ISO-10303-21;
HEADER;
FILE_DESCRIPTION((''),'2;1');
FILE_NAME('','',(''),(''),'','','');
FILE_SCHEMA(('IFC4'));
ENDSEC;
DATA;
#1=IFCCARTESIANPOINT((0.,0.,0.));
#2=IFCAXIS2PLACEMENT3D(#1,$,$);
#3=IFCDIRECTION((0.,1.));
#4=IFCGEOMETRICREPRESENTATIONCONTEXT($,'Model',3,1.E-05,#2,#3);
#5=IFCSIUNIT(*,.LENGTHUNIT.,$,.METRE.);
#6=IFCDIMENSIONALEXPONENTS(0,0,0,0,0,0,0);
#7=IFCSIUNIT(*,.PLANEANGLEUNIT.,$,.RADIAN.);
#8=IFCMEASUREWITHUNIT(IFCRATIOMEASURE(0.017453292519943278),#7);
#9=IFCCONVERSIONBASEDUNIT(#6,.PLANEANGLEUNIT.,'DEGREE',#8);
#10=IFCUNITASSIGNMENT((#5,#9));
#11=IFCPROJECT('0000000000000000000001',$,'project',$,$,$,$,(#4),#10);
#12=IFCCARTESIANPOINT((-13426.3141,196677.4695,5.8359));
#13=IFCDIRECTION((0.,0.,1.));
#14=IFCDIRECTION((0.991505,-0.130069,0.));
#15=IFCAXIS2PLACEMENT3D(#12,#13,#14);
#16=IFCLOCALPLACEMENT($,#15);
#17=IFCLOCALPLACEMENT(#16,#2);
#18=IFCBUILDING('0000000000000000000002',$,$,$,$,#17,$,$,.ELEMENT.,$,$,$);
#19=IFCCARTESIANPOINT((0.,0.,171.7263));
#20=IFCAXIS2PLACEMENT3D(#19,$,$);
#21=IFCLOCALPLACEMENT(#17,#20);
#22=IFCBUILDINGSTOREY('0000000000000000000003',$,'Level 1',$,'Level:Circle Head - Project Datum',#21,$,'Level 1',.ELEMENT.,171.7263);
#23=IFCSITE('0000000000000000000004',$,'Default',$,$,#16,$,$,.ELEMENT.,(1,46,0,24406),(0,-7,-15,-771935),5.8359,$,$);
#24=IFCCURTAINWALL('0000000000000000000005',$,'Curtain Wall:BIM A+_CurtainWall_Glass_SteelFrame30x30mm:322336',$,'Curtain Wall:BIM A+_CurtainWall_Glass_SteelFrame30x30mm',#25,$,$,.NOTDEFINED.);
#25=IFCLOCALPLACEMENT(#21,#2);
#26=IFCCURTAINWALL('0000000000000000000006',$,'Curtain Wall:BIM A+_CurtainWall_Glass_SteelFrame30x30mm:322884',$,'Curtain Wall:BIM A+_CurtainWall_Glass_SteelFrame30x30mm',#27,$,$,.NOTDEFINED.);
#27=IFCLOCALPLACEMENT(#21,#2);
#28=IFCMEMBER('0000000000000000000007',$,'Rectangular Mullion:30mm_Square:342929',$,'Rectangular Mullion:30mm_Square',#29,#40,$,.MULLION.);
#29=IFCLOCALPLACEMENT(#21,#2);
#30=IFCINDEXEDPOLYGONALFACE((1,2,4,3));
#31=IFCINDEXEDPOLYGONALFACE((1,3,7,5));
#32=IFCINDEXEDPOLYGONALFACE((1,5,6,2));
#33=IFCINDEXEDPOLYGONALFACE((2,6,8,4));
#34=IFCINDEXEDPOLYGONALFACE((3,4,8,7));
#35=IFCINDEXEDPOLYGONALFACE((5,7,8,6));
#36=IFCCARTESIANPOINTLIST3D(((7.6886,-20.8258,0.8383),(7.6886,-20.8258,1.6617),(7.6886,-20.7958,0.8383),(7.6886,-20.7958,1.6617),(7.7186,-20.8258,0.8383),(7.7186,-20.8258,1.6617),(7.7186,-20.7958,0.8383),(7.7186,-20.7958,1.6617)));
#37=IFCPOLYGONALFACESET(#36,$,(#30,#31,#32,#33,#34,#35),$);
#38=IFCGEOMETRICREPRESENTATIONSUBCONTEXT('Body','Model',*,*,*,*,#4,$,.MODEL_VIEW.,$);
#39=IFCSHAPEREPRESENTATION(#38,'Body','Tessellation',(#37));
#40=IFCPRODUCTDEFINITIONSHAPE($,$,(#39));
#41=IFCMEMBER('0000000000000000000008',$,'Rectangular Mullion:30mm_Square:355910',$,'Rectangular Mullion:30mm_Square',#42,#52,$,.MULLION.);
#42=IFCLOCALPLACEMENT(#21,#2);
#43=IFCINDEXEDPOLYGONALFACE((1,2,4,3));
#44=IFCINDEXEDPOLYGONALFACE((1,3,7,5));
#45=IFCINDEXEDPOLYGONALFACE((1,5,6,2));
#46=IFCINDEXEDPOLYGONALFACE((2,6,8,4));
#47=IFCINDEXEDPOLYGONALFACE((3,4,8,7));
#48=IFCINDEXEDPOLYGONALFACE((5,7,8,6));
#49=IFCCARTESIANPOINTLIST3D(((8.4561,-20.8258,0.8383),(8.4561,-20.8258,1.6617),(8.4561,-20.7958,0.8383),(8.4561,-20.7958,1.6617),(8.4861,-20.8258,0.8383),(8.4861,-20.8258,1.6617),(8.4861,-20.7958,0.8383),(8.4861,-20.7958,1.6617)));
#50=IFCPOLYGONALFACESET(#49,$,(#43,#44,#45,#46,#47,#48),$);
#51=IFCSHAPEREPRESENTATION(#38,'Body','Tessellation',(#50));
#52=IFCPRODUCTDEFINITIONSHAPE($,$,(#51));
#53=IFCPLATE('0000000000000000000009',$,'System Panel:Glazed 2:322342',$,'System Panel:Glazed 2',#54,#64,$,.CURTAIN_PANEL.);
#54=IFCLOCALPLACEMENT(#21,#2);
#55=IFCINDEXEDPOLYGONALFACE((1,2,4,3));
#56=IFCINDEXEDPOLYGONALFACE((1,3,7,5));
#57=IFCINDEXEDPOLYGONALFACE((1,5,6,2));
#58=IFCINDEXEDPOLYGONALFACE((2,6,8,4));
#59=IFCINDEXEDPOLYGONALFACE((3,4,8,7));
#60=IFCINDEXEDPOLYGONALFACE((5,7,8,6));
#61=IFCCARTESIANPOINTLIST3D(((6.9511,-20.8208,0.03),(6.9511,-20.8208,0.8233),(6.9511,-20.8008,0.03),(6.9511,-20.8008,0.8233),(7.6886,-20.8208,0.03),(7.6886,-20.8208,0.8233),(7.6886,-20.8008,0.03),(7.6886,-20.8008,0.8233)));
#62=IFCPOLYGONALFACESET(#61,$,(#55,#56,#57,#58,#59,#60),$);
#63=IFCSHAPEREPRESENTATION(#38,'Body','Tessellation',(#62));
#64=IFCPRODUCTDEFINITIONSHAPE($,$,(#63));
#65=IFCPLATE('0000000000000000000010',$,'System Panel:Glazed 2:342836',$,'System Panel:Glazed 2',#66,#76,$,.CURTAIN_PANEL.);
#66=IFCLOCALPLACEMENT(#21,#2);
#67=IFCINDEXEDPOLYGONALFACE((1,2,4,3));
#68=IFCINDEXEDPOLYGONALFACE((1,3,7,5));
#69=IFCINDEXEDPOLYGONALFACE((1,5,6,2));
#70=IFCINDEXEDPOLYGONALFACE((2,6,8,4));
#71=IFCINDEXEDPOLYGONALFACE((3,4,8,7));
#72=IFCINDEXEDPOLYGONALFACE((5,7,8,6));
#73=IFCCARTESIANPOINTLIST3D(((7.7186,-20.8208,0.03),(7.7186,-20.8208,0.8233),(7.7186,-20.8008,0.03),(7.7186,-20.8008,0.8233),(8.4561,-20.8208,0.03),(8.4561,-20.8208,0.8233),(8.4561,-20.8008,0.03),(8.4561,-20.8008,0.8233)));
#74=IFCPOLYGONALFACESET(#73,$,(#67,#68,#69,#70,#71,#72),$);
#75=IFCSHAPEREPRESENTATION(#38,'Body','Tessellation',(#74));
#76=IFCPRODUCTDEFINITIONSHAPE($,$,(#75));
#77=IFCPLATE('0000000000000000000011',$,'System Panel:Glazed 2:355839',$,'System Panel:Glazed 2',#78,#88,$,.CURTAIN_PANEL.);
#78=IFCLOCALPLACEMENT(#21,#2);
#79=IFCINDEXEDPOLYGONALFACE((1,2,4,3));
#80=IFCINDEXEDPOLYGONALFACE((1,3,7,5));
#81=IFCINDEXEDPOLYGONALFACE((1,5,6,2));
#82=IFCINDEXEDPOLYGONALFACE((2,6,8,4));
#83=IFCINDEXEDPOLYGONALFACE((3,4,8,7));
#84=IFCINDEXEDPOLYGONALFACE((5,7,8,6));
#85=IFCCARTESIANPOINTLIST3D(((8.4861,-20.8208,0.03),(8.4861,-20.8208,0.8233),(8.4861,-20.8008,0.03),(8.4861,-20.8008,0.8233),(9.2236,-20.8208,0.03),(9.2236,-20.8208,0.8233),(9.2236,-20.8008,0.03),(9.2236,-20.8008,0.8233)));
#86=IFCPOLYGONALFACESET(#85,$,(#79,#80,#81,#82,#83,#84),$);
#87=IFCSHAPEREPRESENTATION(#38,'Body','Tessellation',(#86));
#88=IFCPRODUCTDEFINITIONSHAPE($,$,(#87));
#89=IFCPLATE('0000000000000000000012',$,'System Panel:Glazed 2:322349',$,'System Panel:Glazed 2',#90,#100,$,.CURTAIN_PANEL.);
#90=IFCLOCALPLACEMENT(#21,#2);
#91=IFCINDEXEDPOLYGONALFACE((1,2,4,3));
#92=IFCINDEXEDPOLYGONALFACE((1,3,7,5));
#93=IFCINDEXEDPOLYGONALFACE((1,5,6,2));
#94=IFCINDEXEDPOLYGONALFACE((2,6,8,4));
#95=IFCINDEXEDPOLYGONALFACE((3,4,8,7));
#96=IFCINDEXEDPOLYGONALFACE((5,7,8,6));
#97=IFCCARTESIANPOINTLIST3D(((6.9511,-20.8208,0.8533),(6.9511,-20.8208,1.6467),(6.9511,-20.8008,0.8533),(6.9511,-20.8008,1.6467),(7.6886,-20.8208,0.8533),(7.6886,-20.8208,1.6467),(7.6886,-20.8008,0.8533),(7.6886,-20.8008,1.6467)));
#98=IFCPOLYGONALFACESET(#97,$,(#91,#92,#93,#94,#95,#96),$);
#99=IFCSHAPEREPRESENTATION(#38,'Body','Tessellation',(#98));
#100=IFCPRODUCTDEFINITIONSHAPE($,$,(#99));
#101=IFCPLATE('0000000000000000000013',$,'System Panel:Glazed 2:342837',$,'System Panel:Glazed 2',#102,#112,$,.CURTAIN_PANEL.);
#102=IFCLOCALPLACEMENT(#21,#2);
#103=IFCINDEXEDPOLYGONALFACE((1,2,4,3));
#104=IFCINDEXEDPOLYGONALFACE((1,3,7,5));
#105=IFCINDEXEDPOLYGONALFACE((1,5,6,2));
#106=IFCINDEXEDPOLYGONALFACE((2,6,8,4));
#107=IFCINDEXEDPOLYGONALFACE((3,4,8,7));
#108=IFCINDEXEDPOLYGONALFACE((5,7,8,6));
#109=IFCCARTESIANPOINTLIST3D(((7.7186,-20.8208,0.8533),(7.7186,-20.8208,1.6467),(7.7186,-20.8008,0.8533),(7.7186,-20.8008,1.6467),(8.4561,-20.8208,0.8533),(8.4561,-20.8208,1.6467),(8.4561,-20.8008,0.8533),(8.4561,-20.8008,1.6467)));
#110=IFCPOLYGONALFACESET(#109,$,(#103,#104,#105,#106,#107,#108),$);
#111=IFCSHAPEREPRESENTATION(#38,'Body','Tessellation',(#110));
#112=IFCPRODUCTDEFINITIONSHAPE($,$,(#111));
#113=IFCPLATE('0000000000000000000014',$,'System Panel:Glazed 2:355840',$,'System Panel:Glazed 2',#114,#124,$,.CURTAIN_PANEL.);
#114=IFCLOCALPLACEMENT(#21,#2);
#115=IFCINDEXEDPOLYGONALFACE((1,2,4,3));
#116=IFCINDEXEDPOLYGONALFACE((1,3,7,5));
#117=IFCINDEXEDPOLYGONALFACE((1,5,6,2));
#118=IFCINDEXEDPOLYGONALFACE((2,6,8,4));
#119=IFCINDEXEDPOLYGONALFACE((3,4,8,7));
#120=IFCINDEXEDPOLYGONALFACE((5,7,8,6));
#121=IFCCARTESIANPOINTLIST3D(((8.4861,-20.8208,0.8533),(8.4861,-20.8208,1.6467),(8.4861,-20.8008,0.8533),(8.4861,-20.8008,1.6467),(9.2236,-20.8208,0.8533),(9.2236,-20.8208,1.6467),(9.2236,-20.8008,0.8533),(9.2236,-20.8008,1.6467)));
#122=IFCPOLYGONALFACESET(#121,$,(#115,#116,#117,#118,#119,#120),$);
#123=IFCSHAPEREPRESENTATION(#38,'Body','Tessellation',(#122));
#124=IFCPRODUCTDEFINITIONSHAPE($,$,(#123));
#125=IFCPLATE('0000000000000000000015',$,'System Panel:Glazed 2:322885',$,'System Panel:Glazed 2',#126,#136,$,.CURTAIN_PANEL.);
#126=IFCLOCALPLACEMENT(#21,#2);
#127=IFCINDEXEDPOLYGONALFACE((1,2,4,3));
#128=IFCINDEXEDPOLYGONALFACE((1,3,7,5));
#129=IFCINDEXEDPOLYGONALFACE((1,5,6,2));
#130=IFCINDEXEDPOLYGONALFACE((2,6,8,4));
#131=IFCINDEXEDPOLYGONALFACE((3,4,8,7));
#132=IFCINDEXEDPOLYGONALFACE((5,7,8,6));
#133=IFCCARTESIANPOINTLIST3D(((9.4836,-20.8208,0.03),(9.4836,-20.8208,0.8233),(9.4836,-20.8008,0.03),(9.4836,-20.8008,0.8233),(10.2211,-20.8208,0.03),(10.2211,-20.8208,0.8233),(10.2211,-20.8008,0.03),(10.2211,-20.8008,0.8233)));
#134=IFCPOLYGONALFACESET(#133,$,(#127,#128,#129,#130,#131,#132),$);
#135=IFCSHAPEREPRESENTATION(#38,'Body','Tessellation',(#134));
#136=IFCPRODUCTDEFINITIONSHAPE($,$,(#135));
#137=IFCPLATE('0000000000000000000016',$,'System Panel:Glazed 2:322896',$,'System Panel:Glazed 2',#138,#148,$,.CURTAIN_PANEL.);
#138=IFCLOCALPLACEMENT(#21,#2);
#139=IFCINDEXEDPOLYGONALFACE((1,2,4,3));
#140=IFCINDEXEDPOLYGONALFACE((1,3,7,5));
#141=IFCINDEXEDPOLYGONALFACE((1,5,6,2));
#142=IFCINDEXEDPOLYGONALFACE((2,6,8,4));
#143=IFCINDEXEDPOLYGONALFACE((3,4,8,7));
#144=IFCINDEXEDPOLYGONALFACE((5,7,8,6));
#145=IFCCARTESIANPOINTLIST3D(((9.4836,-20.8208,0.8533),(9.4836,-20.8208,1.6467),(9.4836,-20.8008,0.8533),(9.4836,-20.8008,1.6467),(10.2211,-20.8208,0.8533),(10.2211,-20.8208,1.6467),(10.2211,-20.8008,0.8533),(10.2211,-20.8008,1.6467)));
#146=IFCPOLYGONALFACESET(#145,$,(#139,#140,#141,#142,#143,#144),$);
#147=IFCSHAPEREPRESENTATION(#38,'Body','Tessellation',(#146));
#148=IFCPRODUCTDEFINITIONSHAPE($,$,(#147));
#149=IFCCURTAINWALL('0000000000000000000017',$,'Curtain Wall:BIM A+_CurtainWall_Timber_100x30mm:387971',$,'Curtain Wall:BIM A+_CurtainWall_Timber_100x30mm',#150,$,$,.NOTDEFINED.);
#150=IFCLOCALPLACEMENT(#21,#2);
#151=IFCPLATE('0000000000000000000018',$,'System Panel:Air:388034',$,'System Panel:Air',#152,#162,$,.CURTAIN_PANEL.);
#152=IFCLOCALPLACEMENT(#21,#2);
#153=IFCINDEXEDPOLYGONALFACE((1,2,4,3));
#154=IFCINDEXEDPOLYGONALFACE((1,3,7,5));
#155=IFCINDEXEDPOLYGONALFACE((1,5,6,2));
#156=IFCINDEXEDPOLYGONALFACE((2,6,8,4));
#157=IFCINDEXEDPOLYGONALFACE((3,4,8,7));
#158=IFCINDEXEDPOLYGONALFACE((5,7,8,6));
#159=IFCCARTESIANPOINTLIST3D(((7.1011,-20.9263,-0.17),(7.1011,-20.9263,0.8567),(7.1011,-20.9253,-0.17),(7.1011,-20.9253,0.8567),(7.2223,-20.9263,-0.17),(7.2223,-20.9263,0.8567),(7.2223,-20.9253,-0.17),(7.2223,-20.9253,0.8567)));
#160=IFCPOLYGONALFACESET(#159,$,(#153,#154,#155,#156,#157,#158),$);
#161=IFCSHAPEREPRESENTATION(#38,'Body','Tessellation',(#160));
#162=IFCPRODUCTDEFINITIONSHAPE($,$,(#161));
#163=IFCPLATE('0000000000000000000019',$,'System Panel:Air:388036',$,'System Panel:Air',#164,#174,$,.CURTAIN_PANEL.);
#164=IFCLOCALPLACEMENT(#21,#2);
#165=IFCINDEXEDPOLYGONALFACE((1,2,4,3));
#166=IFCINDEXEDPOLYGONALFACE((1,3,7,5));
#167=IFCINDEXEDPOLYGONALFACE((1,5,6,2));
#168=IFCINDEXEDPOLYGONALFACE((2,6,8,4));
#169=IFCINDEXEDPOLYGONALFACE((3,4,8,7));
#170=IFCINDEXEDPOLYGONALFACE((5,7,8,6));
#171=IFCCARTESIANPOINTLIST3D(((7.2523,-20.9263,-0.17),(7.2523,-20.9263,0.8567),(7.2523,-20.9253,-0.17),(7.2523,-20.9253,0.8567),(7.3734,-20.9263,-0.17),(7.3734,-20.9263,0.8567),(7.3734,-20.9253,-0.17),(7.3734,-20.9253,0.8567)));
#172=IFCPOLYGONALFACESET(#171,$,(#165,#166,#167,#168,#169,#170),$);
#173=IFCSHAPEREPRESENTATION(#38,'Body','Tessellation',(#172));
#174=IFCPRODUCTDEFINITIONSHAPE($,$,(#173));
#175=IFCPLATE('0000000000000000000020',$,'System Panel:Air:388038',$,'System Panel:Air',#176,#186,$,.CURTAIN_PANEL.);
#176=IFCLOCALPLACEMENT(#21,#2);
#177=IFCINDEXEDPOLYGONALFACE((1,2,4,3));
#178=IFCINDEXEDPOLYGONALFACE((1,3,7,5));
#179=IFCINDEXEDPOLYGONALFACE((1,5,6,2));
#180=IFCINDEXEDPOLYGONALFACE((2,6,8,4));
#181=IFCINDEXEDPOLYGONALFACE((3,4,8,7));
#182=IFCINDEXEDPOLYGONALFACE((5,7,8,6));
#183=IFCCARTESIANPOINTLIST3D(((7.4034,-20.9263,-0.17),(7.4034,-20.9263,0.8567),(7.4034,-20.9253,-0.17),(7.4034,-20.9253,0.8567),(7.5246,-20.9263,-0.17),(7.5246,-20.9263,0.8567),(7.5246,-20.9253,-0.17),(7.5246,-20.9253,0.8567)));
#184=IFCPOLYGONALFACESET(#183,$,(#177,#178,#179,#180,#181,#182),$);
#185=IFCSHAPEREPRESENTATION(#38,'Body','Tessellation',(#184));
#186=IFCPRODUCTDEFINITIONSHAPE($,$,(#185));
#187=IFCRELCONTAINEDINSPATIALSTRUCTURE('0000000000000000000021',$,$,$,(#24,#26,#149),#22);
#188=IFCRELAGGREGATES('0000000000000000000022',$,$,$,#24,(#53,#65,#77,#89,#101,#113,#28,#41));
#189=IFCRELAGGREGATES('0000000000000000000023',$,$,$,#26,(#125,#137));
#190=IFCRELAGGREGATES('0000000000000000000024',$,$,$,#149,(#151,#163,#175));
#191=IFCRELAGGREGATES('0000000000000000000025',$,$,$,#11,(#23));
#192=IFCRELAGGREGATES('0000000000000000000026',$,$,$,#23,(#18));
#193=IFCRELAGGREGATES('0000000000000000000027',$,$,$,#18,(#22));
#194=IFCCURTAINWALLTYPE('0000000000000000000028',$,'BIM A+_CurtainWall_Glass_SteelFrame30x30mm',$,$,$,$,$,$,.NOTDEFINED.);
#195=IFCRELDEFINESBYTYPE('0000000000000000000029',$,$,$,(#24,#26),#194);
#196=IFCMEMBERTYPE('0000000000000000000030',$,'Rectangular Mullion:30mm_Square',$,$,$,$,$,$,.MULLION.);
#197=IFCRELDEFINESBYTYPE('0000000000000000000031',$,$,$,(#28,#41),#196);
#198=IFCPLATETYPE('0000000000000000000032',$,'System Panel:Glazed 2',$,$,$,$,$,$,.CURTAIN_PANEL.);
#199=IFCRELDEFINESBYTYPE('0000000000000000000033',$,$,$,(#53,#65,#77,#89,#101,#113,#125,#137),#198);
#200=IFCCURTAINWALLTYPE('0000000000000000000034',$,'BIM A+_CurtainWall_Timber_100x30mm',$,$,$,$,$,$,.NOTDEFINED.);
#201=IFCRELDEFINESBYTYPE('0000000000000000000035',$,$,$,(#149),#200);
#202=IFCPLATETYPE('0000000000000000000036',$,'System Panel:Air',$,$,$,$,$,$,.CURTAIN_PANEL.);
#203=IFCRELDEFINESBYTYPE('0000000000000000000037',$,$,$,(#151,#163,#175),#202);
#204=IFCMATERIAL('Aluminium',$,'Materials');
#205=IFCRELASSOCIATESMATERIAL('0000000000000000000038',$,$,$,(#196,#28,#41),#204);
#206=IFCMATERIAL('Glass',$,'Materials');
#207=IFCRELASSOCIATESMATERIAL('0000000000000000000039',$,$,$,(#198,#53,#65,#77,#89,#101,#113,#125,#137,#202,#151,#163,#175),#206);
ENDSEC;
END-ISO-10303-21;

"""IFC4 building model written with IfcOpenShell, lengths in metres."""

from ifc_helpers import new_model, entity, si_unit, converted_unit, direction, frame, origin, place, context, subcontext, project, spatial, indexed_curve, outline, extrude, source, transform, mapped, material, type_object, type_shapes, element, aggregate, save


model = new_model("IFC4")

# Units and contexts
model_context = context("Model", 3, precision=1e-05, world=origin(), true_north=direction((0.0, 1.0)))
body_context = subcontext(model_context, "Body", "Model", "MODEL_VIEW")
ifc_project = project(units=[si_unit("LENGTHUNIT", "METRE"), converted_unit("PLANEANGLEUNIT", "DEGREE", entity("IfcRatioMeasure", 0.017453292519943278), si_unit("PLANEANGLEUNIT", "RADIAN"), dimensions=[0, 0, 0, 0, 0, 0, 0])], contexts=[model_context])

# Site, building, storey
site_placement = place(None, frame((-13426.3141, 196677.4695, 5.8359), z_axis=(0.0, 0.0, 1.0), x_axis=(0.991505, -0.130069, 0.0)))
site = spatial("IfcSite", under=ifc_project, at=site_placement, Name="Default", CompositionType="ELEMENT", RefLatitude=(1, 46, 0, 24406), RefLongitude=(0, -7, -15, -771935), RefElevation=5.8359)
building_placement = place(site_placement, origin())
building = spatial("IfcBuilding", under=site, at=building_placement, CompositionType="ELEMENT")
storey_placement = place(building_placement, frame((0.0, 0.0, 171.7263)))
storey = spatial("IfcBuildingStorey", under=building, at=storey_placement, Name="Level 1", ObjectType="Level:Circle Head - Project Datum", LongName="Level 1", CompositionType="ELEMENT", Elevation=171.7263)

# Curtain wall
curtain_wall_type_1 = type_object("IfcCurtainWallType", Name="BIM A+_CurtainWall_Glass_SteelFrame30x30mm", PredefinedType="NOTDEFINED")
curtain_wall_1_placement = place(storey_placement, frame((0.0, 0.0, -171.7263)))
curtain_wall_1 = element("IfcCurtainWall", 1, at=curtain_wall_1_placement, inside=storey, type_object=curtain_wall_type_1, Name="Curtain Wall:BIM A+_CurtainWall_Glass_SteelFrame30x30mm:322336", ObjectType="Curtain Wall:BIM A+_CurtainWall_Glass_SteelFrame30x30mm", PredefinedType="NOTDEFINED")
ifc_material_1 = material(Name="Aluminium", Category="Materials")

# Curtain wall
curtain_wall_2_placement = place(storey_placement, frame((0.0, 0.0, -171.7263)))
curtain_wall_2 = element("IfcCurtainWall", 2, at=curtain_wall_2_placement, inside=storey, type_object=curtain_wall_type_1, Name="Curtain Wall:BIM A+_CurtainWall_Glass_SteelFrame30x30mm:322884", ObjectType="Curtain Wall:BIM A+_CurtainWall_Glass_SteelFrame30x30mm", PredefinedType="NOTDEFINED")

# Members
member_type_1 = type_object("IfcMemberType", Name="Rectangular Mullion:30mm_Square", PredefinedType="MULLION", material=ifc_material_1)
shared_shape_1 = source(origin(), body_context, "Body", "SweptSolid", [
    extrude(outline(indexed_curve([(-0.015, -0.015), (0.015, -0.015), (0.015, 0.015), (-0.015, 0.015), (-0.015, -0.015)], self_intersect=False)), frame((0.0, 0.0, -0.8233), z_axis=(0.0, 0.0, 1.0), x_axis=(0.0, -1.0, 0.0)), (0.0, 0.0, 1.0), 0.8233),
])
type_shapes(member_type_1, [shared_shape_1])
member_1_placement = place(curtain_wall_1_placement, frame((7.7036, -20.8108, 172.5646), z_axis=(0.0, 0.0, -1.0), x_axis=(1.0, 0.0, 0.0)))
member_1 = element("IfcMember", 3, at=member_1_placement, type_object=member_type_1, material=ifc_material_1, Name="Rectangular Mullion:30mm_Square:342929", ObjectType="Rectangular Mullion:30mm_Square", PredefinedType="MULLION", context=body_context, shape_type="MappedRepresentation", body=[
    mapped(shared_shape_1, transform((0.0, 0.0, 0.0), scale=1.0)),
])
member_2_placement = place(curtain_wall_1_placement, frame((8.4711, -20.8108, 172.5646), z_axis=(0.0, 0.0, -1.0), x_axis=(1.0, 0.0, 0.0)))
member_2 = element("IfcMember", 4, at=member_2_placement, type_object=member_type_1, material=ifc_material_1, Name="Rectangular Mullion:30mm_Square:355910", ObjectType="Rectangular Mullion:30mm_Square", PredefinedType="MULLION", context=body_context, shape_type="MappedRepresentation", body=[
    mapped(shared_shape_1, transform((0.0, 0.0, 0.0), scale=1.0)),
])

# Plates
ifc_material_2 = material(Name="Glass", Category="Materials")
plate_type_1 = type_object("IfcPlateType", Name="System Panel:Glazed 2", PredefinedType="CURTAIN_PANEL", material=ifc_material_2)
shared_shape_2 = source(origin(), body_context, "Body", "SweptSolid", [
    extrude(outline(indexed_curve([(-0.01, -0.3688), (0.01, -0.3688), (0.01, 0.3688), (-0.01, 0.3688), (-0.01, -0.3688)], self_intersect=False)), frame((0.0, 0.0, 0.0), z_axis=(0.0, 0.0, 1.0), x_axis=(0.0, 1.0, 0.0)), (0.0, 0.0, 1.0), 0.7933),
])
type_shapes(plate_type_1, [shared_shape_2])
plate_1_placement = place(curtain_wall_1_placement, frame((7.3198, -20.8108, 171.7563)))
plate_1 = element("IfcPlate", 5, at=plate_1_placement, type_object=plate_type_1, material=ifc_material_2, Name="System Panel:Glazed 2:322342", ObjectType="System Panel:Glazed 2", PredefinedType="CURTAIN_PANEL", context=body_context, shape_type="MappedRepresentation", body=[
    mapped(shared_shape_2, transform((0.0, 0.0, 0.0), scale=1.0)),
])
plate_2_placement = place(curtain_wall_1_placement, frame((8.0873, -20.8108, 171.7563)))
plate_2 = element("IfcPlate", 6, at=plate_2_placement, type_object=plate_type_1, material=ifc_material_2, Name="System Panel:Glazed 2:342836", ObjectType="System Panel:Glazed 2", PredefinedType="CURTAIN_PANEL", context=body_context, shape_type="MappedRepresentation", body=[
    mapped(shared_shape_2, transform((0.0, 0.0, 0.0), scale=1.0)),
])
plate_3_placement = place(curtain_wall_1_placement, frame((8.8548, -20.8108, 171.7563)))
plate_3 = element("IfcPlate", 7, at=plate_3_placement, type_object=plate_type_1, material=ifc_material_2, Name="System Panel:Glazed 2:355839", ObjectType="System Panel:Glazed 2", PredefinedType="CURTAIN_PANEL", context=body_context, shape_type="MappedRepresentation", body=[
    mapped(shared_shape_2, transform((0.0, 0.0, 0.0), scale=1.0)),
])
plate_4_placement = place(curtain_wall_1_placement, frame((7.3198, -20.8108, 172.5796)))
plate_4 = element("IfcPlate", 8, at=plate_4_placement, type_object=plate_type_1, material=ifc_material_2, Name="System Panel:Glazed 2:322349", ObjectType="System Panel:Glazed 2", PredefinedType="CURTAIN_PANEL", context=body_context, shape_type="MappedRepresentation", body=[
    mapped(shared_shape_2, transform((0.0, 0.0, 0.0), scale=1.0)),
])
plate_5_placement = place(curtain_wall_1_placement, frame((8.0873, -20.8108, 172.5796)))
plate_5 = element("IfcPlate", 9, at=plate_5_placement, type_object=plate_type_1, material=ifc_material_2, Name="System Panel:Glazed 2:342837", ObjectType="System Panel:Glazed 2", PredefinedType="CURTAIN_PANEL", context=body_context, shape_type="MappedRepresentation", body=[
    mapped(shared_shape_2, transform((0.0, 0.0, 0.0), scale=1.0)),
])
plate_6_placement = place(curtain_wall_1_placement, frame((8.8548, -20.8108, 172.5796)))
plate_6 = element("IfcPlate", 10, at=plate_6_placement, type_object=plate_type_1, material=ifc_material_2, Name="System Panel:Glazed 2:355840", ObjectType="System Panel:Glazed 2", PredefinedType="CURTAIN_PANEL", context=body_context, shape_type="MappedRepresentation", body=[
    mapped(shared_shape_2, transform((0.0, 0.0, 0.0), scale=1.0)),
])
aggregate(curtain_wall_1, [plate_1, plate_2, plate_3, plate_4, plate_5, plate_6, member_1, member_2])
plate_7_placement = place(curtain_wall_2_placement, frame((9.8523, -20.8108, 171.7563)))
plate_7 = element("IfcPlate", 11, at=plate_7_placement, type_object=plate_type_1, material=ifc_material_2, Name="System Panel:Glazed 2:322885", ObjectType="System Panel:Glazed 2", PredefinedType="CURTAIN_PANEL", context=body_context, shape_type="MappedRepresentation", body=[
    mapped(shared_shape_2, transform((0.0, 0.0, 0.0), scale=1.0)),
])
plate_8_placement = place(curtain_wall_2_placement, frame((9.8523, -20.8108, 172.5796)))
plate_8 = element("IfcPlate", 12, at=plate_8_placement, type_object=plate_type_1, material=ifc_material_2, Name="System Panel:Glazed 2:322896", ObjectType="System Panel:Glazed 2", PredefinedType="CURTAIN_PANEL", context=body_context, shape_type="MappedRepresentation", body=[
    mapped(shared_shape_2, transform((0.0, 0.0, 0.0), scale=1.0)),
])
aggregate(curtain_wall_2, [plate_7, plate_8])

# Curtain wall, plates
curtain_wall_type_2 = type_object("IfcCurtainWallType", Name="BIM A+_CurtainWall_Timber_100x30mm", PredefinedType="NOTDEFINED")
curtain_wall_3_placement = place(storey_placement, frame((0.0, 0.0, -171.7263)))
curtain_wall_3 = element("IfcCurtainWall", 13, at=curtain_wall_3_placement, inside=storey, type_object=curtain_wall_type_2, Name="Curtain Wall:BIM A+_CurtainWall_Timber_100x30mm:387971", ObjectType="Curtain Wall:BIM A+_CurtainWall_Timber_100x30mm", PredefinedType="NOTDEFINED")
plate_type_2 = type_object("IfcPlateType", Name="System Panel:Air", PredefinedType="CURTAIN_PANEL", material=ifc_material_2)
shared_shape_3 = source(origin(), body_context, "Body", "SweptSolid", [
    extrude(outline(indexed_curve([(-0.0005, -0.0606), (0.0005, -0.0606), (0.0005, 0.0606), (-0.0005, 0.0606), (-0.0005, -0.0606)], self_intersect=False)), frame((0.0, 0.0, 0.0), z_axis=(0.0, 0.0, 1.0), x_axis=(0.0, 1.0, 0.0)), (0.0, 0.0, 1.0), 1.0267),
])
type_shapes(plate_type_2, [shared_shape_3])
plate_9_placement = place(curtain_wall_3_placement, frame((7.1617, -20.9258, 171.5563)))
plate_9 = element("IfcPlate", 14, at=plate_9_placement, type_object=plate_type_2, material=ifc_material_2, Name="System Panel:Air:388034", ObjectType="System Panel:Air", PredefinedType="CURTAIN_PANEL", context=body_context, shape_type="MappedRepresentation", body=[
    mapped(shared_shape_3, transform((0.0, 0.0, 0.0), scale=1.0)),
])
plate_10_placement = place(curtain_wall_3_placement, frame((7.3129, -20.9258, 171.5563)))
plate_10 = element("IfcPlate", 15, at=plate_10_placement, type_object=plate_type_2, material=ifc_material_2, Name="System Panel:Air:388036", ObjectType="System Panel:Air", PredefinedType="CURTAIN_PANEL", context=body_context, shape_type="MappedRepresentation", body=[
    mapped(shared_shape_3, transform((0.0, 0.0, 0.0), scale=1.0)),
])
plate_11_placement = place(curtain_wall_3_placement, frame((7.464, -20.9258, 171.5563)))
plate_11 = element("IfcPlate", 16, at=plate_11_placement, type_object=plate_type_2, material=ifc_material_2, Name="System Panel:Air:388038", ObjectType="System Panel:Air", PredefinedType="CURTAIN_PANEL", context=body_context, shape_type="MappedRepresentation", body=[
    mapped(shared_shape_3, transform((0.0, 0.0, 0.0), scale=1.0)),
])
aggregate(curtain_wall_3, [plate_9, plate_10, plate_11])

save(model, "model.ifc")
